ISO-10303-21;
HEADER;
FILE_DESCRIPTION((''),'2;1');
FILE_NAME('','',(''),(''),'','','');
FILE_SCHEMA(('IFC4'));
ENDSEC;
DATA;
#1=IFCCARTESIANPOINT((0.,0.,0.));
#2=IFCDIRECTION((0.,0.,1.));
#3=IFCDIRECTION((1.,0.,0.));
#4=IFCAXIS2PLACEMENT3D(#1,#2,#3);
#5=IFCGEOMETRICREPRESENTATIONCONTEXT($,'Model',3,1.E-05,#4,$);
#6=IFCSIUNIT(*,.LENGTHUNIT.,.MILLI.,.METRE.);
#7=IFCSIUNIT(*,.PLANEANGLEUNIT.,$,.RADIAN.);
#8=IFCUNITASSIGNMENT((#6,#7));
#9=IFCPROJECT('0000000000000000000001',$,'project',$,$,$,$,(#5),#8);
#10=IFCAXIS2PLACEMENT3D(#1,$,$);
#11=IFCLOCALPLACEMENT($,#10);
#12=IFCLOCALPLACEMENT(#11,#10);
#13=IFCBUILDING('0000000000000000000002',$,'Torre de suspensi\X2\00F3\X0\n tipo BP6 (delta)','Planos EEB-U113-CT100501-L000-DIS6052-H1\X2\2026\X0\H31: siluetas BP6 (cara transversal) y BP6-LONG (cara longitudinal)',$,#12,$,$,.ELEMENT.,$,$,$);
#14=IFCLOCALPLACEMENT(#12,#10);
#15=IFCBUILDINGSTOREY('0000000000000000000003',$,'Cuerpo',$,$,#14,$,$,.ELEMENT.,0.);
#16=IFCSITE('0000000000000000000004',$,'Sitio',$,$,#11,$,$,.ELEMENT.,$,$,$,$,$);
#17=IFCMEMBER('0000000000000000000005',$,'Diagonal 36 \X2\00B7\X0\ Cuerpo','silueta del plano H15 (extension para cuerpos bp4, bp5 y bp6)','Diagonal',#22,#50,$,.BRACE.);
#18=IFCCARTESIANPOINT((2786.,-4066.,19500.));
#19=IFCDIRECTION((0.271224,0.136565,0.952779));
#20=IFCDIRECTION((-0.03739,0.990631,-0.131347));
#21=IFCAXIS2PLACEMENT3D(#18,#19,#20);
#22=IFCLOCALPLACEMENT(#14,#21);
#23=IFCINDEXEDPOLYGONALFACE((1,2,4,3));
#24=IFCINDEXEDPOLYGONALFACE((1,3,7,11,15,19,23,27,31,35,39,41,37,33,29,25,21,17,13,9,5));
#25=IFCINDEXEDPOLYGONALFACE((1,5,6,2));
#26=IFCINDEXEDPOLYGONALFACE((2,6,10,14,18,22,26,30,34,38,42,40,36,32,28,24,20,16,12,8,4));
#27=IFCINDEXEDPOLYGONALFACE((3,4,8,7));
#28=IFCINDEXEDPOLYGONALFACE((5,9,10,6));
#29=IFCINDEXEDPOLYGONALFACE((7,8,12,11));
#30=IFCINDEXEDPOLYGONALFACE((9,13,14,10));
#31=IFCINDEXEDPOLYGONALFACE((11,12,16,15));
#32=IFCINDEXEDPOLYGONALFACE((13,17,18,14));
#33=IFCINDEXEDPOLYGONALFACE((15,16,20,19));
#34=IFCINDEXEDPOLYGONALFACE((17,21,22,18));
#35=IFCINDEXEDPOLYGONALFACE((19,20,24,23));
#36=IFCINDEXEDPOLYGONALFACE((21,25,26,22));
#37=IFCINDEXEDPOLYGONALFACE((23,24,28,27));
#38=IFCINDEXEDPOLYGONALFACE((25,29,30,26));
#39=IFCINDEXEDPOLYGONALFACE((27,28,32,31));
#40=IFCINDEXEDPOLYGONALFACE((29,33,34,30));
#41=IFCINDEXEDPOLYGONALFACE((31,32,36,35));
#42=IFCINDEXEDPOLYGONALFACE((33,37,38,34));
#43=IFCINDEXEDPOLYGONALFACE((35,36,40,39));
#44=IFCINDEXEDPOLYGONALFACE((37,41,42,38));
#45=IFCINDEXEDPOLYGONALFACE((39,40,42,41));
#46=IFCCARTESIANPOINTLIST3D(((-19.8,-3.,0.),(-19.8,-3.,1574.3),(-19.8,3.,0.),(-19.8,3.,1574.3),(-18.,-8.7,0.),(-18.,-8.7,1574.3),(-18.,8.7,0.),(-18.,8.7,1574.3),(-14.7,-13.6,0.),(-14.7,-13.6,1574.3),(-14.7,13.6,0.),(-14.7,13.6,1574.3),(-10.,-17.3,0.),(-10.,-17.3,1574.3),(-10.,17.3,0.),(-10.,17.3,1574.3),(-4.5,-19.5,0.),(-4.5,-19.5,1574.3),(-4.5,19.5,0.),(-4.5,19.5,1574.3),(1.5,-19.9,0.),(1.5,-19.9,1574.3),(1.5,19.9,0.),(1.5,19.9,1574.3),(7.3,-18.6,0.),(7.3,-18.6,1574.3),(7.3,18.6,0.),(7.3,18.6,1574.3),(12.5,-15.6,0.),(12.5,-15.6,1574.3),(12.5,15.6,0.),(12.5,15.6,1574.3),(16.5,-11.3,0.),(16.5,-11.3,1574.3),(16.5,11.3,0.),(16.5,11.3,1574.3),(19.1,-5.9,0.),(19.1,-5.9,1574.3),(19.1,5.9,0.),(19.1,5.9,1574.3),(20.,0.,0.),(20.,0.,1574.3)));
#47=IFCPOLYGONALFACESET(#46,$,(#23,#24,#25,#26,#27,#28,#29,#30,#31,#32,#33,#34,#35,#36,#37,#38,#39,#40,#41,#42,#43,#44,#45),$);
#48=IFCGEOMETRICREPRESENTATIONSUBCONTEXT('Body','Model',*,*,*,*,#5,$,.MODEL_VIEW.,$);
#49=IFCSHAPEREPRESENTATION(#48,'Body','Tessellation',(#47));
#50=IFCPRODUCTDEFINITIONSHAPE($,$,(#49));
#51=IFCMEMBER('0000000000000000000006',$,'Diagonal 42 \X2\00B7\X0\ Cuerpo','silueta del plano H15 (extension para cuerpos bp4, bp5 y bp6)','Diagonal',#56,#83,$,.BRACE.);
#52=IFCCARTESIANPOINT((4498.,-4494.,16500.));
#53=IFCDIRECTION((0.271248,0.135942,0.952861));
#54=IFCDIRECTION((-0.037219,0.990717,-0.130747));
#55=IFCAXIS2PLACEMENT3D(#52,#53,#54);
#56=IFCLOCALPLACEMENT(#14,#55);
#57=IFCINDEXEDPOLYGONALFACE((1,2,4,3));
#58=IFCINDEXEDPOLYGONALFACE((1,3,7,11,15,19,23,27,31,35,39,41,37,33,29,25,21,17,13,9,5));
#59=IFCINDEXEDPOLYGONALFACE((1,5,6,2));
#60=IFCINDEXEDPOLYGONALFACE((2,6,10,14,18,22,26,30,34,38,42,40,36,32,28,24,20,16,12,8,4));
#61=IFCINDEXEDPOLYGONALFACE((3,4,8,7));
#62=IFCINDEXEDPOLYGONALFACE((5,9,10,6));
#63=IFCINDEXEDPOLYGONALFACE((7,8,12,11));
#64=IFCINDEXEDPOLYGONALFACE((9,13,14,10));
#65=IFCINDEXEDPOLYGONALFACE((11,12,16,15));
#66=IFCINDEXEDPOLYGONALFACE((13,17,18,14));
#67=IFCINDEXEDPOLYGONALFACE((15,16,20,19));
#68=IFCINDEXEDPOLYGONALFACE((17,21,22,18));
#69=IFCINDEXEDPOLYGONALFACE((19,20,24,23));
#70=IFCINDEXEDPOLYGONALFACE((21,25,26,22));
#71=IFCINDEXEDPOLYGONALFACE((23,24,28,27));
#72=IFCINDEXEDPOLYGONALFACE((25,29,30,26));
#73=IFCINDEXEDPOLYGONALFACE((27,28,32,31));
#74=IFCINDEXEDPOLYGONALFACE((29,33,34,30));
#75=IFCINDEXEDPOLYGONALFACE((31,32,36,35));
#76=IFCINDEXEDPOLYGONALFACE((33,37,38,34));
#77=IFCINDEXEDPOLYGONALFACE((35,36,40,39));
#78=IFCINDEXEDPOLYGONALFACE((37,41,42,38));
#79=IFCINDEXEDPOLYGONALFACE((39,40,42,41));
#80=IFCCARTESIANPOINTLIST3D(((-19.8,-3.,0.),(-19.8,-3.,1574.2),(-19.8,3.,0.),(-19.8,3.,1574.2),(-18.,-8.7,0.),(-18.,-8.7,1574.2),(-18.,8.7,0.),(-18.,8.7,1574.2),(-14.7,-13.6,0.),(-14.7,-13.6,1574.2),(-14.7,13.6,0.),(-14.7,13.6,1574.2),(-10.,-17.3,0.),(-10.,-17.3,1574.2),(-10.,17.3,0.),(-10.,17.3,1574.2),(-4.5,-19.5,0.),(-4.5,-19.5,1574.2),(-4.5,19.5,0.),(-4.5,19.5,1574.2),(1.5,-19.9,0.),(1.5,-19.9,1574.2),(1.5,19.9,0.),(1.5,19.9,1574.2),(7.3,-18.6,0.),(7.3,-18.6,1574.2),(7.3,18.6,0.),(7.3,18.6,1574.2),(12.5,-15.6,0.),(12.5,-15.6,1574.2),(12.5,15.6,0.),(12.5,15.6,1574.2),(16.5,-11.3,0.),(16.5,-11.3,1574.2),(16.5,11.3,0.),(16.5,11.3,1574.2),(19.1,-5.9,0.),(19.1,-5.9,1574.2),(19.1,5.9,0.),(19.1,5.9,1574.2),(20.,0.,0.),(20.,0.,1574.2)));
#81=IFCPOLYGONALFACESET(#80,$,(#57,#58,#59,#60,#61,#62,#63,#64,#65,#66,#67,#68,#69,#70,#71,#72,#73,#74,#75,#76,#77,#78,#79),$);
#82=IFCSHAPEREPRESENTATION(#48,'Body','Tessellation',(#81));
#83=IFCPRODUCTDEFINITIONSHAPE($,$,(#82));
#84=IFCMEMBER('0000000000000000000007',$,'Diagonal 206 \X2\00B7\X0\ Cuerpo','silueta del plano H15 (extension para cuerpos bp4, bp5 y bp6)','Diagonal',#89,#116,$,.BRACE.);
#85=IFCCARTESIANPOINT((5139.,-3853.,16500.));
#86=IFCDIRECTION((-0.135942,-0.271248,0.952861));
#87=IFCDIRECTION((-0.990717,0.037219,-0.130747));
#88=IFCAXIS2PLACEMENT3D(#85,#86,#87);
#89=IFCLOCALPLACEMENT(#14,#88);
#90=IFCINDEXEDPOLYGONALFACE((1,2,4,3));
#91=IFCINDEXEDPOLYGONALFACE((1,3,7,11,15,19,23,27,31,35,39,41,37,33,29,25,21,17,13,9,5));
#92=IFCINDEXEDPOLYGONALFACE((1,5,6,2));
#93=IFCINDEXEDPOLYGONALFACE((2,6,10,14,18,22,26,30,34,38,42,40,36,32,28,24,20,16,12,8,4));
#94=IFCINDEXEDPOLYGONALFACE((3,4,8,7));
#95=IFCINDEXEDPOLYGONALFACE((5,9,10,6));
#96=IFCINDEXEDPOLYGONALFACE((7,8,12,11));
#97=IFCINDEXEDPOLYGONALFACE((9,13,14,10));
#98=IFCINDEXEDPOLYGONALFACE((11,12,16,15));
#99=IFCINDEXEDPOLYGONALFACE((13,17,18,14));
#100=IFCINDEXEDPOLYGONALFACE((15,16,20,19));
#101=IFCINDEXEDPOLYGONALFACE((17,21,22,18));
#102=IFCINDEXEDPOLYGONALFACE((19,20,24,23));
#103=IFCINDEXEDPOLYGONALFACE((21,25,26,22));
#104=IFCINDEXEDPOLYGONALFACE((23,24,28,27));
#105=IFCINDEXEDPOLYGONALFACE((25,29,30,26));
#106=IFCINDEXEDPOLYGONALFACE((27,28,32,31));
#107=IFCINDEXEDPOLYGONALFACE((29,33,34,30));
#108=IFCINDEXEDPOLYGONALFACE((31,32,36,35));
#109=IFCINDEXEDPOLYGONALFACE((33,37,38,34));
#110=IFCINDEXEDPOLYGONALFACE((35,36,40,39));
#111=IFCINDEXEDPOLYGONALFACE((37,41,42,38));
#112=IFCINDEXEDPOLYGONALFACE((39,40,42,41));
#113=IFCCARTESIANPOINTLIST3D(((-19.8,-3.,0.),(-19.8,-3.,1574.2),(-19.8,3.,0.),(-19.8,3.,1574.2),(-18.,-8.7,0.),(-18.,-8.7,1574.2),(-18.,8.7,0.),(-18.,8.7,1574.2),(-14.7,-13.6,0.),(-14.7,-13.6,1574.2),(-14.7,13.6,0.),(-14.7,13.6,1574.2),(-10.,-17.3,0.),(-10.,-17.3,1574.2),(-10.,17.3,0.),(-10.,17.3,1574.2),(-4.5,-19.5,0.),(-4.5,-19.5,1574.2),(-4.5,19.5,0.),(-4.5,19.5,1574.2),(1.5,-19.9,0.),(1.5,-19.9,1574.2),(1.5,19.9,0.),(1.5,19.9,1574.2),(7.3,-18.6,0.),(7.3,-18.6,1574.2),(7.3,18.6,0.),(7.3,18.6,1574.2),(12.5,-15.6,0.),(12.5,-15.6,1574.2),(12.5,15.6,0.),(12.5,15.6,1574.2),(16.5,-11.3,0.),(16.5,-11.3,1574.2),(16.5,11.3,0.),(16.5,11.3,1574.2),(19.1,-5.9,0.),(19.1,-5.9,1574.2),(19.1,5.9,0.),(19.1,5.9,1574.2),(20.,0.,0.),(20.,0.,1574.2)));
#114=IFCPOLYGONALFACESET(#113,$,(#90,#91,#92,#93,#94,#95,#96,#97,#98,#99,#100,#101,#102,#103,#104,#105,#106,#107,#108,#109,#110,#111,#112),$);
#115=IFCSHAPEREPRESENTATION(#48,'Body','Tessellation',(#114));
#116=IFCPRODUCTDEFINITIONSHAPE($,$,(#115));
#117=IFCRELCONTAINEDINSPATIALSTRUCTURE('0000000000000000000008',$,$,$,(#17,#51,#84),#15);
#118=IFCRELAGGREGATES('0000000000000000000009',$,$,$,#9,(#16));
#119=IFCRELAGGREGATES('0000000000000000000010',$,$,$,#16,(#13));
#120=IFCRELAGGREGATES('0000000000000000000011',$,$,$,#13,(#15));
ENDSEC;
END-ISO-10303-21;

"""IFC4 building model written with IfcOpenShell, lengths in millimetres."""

from ifc_helpers import new_model, si_unit, frame, origin, origin_with_axes, place, context, subcontext, project, spatial, circle, extrude, element, save


model = new_model("IFC4")

# Units and contexts
model_context = context("Model", 3, precision=1e-05, world=origin_with_axes())
body_context = subcontext(model_context, "Body", "Model", "MODEL_VIEW")
ifc_project = project(units=[si_unit("LENGTHUNIT", "METRE", prefix="MILLI"), si_unit("PLANEANGLEUNIT", "RADIAN")], contexts=[model_context])

# Site, building, storey
site_placement = place(None, origin())
site = spatial("IfcSite", under=ifc_project, at=site_placement, Name="Sitio", CompositionType="ELEMENT")
building_placement = place(site_placement, origin())
building = spatial("IfcBuilding", under=site, at=building_placement, Name="Torre de suspensión tipo BP6 (delta)", Description="Planos EEB-U113-CT100501-L000-DIS6052-H1…H31: siluetas BP6 (cara transversal) y BP6-LONG (cara longitudinal)", CompositionType="ELEMENT")
storey_placement = place(building_placement, origin())
storey = spatial("IfcBuildingStorey", under=building, at=storey_placement, Name="Cuerpo", CompositionType="ELEMENT", Elevation=0.0)

# Members
member_1_placement = place(storey_placement, frame((2786.0, -4066.0, 19500.0), z_axis=(0.271224, 0.136565, 0.952779), x_axis=(-0.03739, 0.990631, -0.131347)))
element("IfcMember", 1, at=member_1_placement, inside=storey, Name="Diagonal 36 · Cuerpo", Description="silueta del plano H15 (extension para cuerpos bp4, bp5 y bp6)", ObjectType="Diagonal", PredefinedType="BRACE", context=body_context, shape_type="SweptSolid", body=[
    extrude(circle(Radius=20.0), None, (0.0, 0.0, 1.0), 1574.3),
])
member_2_placement = place(storey_placement, frame((4498.0, -4494.0, 16500.0), z_axis=(0.271248, 0.135942, 0.952861), x_axis=(-0.037219, 0.990717, -0.130747)))
element("IfcMember", 2, at=member_2_placement, inside=storey, Name="Diagonal 42 · Cuerpo", Description="silueta del plano H15 (extension para cuerpos bp4, bp5 y bp6)", ObjectType="Diagonal", PredefinedType="BRACE", context=body_context, shape_type="SweptSolid", body=[
    extrude(circle(Radius=20.0), None, (0.0, 0.0, 1.0), 1574.2),
])
member_3_placement = place(storey_placement, frame((5139.0, -3853.0, 16500.0), z_axis=(-0.135942, -0.271248, 0.952861), x_axis=(-0.990717, 0.037219, -0.130747)))
element("IfcMember", 3, at=member_3_placement, inside=storey, Name="Diagonal 206 · Cuerpo", Description="silueta del plano H15 (extension para cuerpos bp4, bp5 y bp6)", ObjectType="Diagonal", PredefinedType="BRACE", context=body_context, shape_type="SweptSolid", body=[
    extrude(circle(Radius=20.0), None, (0.0, 0.0, 1.0), 1574.2),
])

save(model, "model.ifc")
